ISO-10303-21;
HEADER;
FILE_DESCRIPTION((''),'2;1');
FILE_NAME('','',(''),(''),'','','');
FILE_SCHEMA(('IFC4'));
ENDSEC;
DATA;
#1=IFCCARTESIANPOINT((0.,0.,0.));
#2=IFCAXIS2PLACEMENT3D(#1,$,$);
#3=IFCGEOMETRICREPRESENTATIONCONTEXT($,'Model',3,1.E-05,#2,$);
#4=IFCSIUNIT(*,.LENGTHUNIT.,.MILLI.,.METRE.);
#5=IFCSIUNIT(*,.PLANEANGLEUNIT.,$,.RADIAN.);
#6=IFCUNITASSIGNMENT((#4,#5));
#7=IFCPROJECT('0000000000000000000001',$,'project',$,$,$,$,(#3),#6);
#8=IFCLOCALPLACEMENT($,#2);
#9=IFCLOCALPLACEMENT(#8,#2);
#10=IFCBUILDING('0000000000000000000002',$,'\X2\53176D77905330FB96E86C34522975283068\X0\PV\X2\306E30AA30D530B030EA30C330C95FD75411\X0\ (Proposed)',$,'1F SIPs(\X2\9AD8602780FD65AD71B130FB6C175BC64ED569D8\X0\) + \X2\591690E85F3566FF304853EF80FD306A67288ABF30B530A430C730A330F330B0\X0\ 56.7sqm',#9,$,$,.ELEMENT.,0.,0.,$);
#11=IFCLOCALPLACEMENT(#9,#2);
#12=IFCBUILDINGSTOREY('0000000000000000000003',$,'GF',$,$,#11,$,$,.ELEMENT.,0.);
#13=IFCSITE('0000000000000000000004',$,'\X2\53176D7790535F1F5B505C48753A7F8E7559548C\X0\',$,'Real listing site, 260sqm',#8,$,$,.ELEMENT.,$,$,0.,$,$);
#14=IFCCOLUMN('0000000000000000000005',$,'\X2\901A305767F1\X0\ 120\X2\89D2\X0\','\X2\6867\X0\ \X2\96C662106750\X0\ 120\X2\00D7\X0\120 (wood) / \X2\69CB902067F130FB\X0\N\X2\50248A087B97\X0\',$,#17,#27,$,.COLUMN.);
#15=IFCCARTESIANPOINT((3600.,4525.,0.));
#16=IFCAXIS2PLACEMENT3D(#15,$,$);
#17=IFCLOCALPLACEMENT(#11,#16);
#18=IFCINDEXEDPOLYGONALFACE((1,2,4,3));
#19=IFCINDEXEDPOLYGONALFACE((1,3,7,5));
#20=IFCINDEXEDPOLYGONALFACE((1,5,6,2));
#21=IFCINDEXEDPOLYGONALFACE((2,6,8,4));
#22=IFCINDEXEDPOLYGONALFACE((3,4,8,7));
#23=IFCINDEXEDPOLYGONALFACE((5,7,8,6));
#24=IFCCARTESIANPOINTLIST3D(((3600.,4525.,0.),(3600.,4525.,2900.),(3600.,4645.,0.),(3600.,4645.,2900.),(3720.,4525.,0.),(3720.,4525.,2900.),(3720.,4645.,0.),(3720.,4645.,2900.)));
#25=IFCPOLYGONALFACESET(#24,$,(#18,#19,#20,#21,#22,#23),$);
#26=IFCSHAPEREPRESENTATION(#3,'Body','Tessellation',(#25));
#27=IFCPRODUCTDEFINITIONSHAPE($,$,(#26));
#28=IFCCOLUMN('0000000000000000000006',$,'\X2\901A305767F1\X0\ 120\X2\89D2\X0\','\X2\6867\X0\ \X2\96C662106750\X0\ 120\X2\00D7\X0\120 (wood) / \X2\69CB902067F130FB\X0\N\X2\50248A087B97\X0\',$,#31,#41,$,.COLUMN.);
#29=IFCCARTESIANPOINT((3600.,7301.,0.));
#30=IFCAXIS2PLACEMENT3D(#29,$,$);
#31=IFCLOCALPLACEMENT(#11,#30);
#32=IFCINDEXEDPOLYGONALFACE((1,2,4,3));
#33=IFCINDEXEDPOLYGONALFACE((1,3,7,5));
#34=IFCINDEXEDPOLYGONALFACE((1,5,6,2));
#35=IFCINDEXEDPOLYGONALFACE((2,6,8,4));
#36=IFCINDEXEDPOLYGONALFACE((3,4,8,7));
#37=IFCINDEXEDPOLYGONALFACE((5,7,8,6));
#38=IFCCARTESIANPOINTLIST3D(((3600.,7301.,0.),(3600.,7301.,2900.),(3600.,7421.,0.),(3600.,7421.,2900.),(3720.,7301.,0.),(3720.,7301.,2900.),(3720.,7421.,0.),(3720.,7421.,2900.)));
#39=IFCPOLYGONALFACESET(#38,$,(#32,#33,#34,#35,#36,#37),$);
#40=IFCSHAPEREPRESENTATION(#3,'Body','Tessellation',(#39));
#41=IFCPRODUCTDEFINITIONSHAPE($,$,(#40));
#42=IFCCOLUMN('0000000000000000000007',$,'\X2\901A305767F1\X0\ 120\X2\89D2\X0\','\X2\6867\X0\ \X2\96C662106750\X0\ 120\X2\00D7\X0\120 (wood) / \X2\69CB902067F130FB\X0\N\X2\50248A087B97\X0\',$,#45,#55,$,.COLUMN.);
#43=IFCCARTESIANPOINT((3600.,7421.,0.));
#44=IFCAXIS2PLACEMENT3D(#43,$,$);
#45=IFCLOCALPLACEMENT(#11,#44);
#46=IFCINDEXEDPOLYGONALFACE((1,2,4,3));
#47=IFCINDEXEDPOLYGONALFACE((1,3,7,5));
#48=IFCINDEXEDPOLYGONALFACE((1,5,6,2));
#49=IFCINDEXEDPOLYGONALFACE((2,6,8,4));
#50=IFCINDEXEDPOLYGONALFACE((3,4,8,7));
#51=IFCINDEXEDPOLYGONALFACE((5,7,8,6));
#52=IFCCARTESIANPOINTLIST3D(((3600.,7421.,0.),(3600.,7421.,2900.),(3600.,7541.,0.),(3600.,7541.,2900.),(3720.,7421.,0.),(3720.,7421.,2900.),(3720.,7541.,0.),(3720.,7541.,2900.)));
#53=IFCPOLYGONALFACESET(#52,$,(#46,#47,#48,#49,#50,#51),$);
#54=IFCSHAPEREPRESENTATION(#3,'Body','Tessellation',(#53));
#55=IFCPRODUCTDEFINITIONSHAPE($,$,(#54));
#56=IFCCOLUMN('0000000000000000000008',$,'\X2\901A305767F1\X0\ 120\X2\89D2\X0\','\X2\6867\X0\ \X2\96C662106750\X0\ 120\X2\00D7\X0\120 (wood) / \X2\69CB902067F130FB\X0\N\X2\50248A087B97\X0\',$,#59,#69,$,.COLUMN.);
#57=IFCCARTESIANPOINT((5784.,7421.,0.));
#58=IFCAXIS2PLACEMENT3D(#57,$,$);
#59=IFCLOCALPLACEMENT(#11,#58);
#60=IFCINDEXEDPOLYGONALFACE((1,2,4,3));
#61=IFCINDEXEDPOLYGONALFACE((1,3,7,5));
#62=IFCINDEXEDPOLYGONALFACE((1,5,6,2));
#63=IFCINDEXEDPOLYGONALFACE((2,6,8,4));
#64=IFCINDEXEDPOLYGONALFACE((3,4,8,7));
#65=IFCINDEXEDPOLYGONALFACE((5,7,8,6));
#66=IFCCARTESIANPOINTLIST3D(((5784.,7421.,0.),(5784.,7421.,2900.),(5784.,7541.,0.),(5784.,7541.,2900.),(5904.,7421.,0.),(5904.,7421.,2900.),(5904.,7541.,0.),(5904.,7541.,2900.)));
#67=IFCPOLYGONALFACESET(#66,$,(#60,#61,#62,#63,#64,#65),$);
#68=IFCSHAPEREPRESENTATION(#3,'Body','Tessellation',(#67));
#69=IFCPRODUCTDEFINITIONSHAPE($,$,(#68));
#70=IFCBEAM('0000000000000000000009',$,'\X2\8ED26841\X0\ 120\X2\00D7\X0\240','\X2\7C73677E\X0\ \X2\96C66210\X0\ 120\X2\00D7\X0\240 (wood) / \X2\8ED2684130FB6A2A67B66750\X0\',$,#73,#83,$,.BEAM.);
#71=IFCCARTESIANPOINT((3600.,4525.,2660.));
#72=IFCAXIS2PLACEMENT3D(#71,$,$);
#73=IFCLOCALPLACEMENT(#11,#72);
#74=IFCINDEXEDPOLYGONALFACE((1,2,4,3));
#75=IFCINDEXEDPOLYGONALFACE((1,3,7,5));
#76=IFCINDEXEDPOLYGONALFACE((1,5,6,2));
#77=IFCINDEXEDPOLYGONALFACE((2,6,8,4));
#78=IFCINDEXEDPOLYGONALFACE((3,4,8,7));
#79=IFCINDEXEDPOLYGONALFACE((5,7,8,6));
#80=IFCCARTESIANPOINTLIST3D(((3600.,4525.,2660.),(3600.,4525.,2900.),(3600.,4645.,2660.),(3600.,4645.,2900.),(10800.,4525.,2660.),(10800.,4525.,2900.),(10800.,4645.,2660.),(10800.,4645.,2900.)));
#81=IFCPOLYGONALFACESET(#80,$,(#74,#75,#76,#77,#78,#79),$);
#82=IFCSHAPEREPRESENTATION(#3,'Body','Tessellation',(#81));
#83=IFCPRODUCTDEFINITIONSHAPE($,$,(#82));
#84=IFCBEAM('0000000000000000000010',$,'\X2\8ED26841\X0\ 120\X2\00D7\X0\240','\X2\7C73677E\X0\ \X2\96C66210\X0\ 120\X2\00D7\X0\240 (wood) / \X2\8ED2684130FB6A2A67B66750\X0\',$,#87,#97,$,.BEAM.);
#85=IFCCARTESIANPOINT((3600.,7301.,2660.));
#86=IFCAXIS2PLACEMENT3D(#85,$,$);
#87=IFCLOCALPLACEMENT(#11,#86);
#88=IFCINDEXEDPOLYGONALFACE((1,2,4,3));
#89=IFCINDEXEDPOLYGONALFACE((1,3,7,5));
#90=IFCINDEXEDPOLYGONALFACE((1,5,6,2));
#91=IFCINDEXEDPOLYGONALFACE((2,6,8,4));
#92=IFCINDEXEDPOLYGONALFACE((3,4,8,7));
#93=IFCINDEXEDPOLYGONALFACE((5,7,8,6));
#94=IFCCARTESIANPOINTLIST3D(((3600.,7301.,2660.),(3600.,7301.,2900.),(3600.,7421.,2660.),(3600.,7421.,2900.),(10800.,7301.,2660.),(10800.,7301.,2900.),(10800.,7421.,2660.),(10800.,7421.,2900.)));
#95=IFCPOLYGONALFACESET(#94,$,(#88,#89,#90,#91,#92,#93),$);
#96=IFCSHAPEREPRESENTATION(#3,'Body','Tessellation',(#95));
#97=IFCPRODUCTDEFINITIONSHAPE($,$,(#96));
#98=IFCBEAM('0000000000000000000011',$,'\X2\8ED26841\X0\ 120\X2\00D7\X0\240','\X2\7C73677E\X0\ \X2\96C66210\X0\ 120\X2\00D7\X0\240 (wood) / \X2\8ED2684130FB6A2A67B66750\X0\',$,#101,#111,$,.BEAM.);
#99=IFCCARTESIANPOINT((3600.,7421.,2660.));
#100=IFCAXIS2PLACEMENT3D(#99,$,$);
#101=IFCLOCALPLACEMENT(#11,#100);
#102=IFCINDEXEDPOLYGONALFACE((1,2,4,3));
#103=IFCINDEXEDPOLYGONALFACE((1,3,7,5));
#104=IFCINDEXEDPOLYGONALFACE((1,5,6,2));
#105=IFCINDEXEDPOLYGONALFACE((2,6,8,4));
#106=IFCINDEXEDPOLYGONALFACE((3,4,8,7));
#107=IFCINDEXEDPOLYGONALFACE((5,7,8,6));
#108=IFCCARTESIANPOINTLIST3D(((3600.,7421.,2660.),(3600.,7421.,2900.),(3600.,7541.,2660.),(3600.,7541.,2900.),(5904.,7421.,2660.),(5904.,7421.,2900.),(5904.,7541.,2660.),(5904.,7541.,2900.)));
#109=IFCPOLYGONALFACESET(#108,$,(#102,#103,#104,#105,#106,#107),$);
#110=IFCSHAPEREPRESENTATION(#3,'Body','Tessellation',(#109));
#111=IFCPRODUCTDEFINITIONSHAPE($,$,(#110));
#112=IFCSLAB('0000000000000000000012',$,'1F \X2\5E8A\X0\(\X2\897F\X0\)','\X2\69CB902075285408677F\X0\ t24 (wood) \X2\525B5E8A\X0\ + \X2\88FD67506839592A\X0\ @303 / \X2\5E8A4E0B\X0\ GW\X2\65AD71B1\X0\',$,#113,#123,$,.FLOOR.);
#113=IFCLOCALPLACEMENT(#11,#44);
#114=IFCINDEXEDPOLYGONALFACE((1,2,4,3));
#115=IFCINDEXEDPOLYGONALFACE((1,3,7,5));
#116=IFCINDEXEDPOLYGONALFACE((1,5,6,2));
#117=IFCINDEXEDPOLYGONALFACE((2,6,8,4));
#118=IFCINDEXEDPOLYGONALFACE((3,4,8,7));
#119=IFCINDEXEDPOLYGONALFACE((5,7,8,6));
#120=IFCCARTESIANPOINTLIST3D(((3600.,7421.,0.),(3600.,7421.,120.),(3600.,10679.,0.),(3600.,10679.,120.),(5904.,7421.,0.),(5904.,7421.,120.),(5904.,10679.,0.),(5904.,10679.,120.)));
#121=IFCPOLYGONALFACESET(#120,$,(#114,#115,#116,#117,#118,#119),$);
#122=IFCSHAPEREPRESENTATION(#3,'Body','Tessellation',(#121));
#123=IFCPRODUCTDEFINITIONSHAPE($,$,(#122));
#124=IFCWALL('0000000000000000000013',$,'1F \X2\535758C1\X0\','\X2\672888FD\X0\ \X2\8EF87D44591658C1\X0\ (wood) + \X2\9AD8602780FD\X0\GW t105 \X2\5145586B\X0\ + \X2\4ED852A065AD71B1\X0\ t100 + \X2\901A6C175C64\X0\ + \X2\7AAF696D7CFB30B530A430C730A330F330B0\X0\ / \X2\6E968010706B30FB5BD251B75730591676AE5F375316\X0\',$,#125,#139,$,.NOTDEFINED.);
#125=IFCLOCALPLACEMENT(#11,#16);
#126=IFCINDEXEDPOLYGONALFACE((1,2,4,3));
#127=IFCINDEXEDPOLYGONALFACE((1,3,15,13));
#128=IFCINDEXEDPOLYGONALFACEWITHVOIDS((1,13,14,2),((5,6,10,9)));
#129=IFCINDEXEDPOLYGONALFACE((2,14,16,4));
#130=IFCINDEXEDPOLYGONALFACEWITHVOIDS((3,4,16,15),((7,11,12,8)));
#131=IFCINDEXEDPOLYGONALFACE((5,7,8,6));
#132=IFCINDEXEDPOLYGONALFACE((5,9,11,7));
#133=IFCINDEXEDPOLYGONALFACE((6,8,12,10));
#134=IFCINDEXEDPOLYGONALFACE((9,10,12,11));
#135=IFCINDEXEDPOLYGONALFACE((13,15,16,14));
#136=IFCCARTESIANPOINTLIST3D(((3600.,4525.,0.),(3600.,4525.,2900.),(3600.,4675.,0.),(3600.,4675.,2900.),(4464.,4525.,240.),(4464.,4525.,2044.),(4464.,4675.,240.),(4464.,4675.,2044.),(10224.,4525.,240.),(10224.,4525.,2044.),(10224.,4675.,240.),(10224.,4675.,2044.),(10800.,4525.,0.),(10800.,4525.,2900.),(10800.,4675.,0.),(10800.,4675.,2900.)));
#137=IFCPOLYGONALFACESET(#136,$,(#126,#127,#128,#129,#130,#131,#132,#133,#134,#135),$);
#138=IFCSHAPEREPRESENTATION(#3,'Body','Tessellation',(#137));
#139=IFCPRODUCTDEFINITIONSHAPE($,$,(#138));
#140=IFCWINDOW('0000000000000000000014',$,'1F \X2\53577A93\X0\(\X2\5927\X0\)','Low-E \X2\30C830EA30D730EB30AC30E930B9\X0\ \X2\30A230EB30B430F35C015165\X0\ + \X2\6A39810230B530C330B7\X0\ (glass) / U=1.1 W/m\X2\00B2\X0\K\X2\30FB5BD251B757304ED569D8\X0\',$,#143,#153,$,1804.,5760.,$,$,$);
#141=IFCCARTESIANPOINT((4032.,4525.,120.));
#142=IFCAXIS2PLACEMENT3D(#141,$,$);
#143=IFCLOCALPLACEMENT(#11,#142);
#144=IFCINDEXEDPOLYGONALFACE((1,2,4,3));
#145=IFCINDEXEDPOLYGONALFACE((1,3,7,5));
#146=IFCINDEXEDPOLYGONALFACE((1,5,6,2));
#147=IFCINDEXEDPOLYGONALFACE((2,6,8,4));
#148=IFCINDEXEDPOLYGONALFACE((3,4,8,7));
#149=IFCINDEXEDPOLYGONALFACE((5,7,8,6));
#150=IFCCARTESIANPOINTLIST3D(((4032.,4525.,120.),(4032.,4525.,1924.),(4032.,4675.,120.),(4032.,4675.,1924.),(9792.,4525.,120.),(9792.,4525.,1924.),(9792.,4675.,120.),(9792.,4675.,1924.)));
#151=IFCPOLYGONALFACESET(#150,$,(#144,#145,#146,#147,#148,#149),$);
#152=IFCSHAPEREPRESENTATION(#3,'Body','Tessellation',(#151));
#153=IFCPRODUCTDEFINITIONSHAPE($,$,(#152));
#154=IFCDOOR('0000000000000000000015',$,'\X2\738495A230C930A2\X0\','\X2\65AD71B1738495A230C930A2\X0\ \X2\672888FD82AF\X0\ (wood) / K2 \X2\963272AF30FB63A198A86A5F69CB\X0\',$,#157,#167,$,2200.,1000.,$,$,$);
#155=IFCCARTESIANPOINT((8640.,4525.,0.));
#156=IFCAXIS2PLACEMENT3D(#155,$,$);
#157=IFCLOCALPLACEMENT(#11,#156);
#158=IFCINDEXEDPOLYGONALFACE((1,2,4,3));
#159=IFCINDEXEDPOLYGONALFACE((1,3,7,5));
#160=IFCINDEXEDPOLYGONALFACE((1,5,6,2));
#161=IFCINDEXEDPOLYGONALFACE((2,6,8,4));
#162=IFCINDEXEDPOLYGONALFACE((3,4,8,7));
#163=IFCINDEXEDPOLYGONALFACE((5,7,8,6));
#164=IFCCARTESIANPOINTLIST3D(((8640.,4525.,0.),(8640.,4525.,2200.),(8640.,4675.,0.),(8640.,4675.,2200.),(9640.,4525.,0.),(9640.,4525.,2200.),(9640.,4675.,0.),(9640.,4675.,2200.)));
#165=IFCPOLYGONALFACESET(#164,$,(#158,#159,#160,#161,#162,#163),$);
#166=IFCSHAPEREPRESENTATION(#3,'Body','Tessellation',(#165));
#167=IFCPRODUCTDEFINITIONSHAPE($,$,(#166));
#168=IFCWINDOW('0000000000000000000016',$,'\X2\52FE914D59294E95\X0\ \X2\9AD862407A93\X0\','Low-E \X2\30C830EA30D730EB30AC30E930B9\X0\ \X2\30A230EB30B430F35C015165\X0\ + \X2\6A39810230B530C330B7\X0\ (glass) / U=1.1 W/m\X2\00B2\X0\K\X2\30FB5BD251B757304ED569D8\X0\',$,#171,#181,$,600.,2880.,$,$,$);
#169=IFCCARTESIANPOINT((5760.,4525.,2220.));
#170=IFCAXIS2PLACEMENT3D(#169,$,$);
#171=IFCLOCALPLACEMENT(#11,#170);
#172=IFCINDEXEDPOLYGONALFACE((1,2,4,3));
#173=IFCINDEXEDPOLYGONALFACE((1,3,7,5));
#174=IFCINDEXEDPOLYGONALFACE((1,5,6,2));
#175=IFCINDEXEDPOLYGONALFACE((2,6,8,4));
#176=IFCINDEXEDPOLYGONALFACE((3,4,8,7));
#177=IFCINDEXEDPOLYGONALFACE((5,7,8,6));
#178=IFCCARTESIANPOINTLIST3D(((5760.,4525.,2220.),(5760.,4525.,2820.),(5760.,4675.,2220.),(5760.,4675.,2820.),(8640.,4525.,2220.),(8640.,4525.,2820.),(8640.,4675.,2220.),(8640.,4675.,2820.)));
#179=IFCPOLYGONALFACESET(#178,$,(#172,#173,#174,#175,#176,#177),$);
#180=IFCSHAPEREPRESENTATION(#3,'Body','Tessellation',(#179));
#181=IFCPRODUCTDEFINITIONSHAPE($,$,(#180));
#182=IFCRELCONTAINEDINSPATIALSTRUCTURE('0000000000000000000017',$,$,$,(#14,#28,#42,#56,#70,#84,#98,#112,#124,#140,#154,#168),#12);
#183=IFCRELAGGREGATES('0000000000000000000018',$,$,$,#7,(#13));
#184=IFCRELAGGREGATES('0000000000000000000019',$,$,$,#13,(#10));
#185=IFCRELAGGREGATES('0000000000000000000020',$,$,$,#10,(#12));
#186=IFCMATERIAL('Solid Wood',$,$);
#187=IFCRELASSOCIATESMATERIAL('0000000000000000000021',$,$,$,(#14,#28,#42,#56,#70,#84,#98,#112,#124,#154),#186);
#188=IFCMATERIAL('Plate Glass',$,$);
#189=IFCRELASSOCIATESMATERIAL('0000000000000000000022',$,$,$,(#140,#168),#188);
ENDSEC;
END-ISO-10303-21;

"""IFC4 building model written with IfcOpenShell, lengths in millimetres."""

from ifc_helpers import new_model, si_unit, frame, frame_2d, origin, place, context, project, spatial, rectangle, extrude, material, element, fill, save


model = new_model("IFC4")

# Units and contexts
model_context = context("Model", 3, precision=1e-05, world=origin())
ifc_project = project(units=[si_unit("LENGTHUNIT", "METRE", prefix="MILLI"), si_unit("PLANEANGLEUNIT", "RADIAN")], contexts=[model_context])

# Site, building, storey
site_placement = place(None, origin())
site = spatial("IfcSite", under=ifc_project, at=site_placement, Name="北海道弟子屈町美留和", ObjectType="Real listing site, 260sqm", CompositionType="ELEMENT", RefElevation=0.0)
building_placement = place(site_placement, origin())
building = spatial("IfcBuilding", under=site, at=building_placement, Name="北海道・雨水利用とPVのオフグリッド志向 (Proposed)", ObjectType="1F SIPs(高性能断熱・気密仕様) + 外部張替え可能な木調サイディング 56.7sqm", CompositionType="ELEMENT", ElevationOfRefHeight=0.0, ElevationOfTerrain=0.0)
storey_placement = place(building_placement, origin())
storey = spatial("IfcBuildingStorey", under=building, at=storey_placement, Name="GF", CompositionType="ELEMENT", Elevation=0.0)

# Columns
ifc_material_1 = material(Name="Solid Wood")
column_1_placement = place(storey_placement, frame((3600.0, 4525.0, 0.0)))
element("IfcColumn", 1, at=column_1_placement, inside=storey, material=ifc_material_1, Name="通し柱 120角", Description="桧 集成材 120×120 (wood) / 構造柱・N値計算", PredefinedType="COLUMN", context=model_context, shape_type="SweptSolid", body=[
    extrude(rectangle(XDim=120.0, YDim=120.0, at=frame_2d((60.0, 60.0))), frame((3600.0, 4525.0, 0.0)), (0.0, 0.0, 1.0), 2900.0),
])
column_2_placement = place(storey_placement, frame((3600.0, 7301.0, 0.0)))
element("IfcColumn", 2, at=column_2_placement, inside=storey, material=ifc_material_1, Name="通し柱 120角", Description="桧 集成材 120×120 (wood) / 構造柱・N値計算", PredefinedType="COLUMN", context=model_context, shape_type="SweptSolid", body=[
    extrude(rectangle(XDim=120.0, YDim=120.0, at=frame_2d((60.0, 60.0))), frame((3600.0, 7301.0, 0.0)), (0.0, 0.0, 1.0), 2900.0),
])
column_3_placement = place(storey_placement, frame((3600.0, 7421.0, 0.0)))
element("IfcColumn", 3, at=column_3_placement, inside=storey, material=ifc_material_1, Name="通し柱 120角", Description="桧 集成材 120×120 (wood) / 構造柱・N値計算", PredefinedType="COLUMN", context=model_context, shape_type="SweptSolid", body=[
    extrude(rectangle(XDim=120.0, YDim=120.0, at=frame_2d((60.0, 60.0))), frame((3600.0, 7421.0, 0.0)), (0.0, 0.0, 1.0), 2900.0),
])
column_4_placement = place(storey_placement, frame((5784.0, 7421.0, 0.0)))
element("IfcColumn", 4, at=column_4_placement, inside=storey, material=ifc_material_1, Name="通し柱 120角", Description="桧 集成材 120×120 (wood) / 構造柱・N値計算", PredefinedType="COLUMN", context=model_context, shape_type="SweptSolid", body=[
    extrude(rectangle(XDim=120.0, YDim=120.0, at=frame_2d((60.0, 60.0))), frame((5784.0, 7421.0, 0.0)), (0.0, 0.0, 1.0), 2900.0),
])

# Beams
beam_1_placement = place(storey_placement, frame((3600.0, 4525.0, 2660.0)))
element("IfcBeam", 5, at=beam_1_placement, inside=storey, material=ifc_material_1, Name="軒桁 120×240", Description="米松 集成 120×240 (wood) / 軒桁・横架材", PredefinedType="BEAM", context=model_context, shape_type="SweptSolid", body=[
    extrude(rectangle(XDim=7200.0, YDim=120.0, at=frame_2d((3600.0, 60.0))), frame((3600.0, 4525.0, 2660.0)), (0.0, 0.0, 1.0), 240.0),
])
beam_2_placement = place(storey_placement, frame((3600.0, 7301.0, 2660.0)))
element("IfcBeam", 6, at=beam_2_placement, inside=storey, material=ifc_material_1, Name="軒桁 120×240", Description="米松 集成 120×240 (wood) / 軒桁・横架材", PredefinedType="BEAM", context=model_context, shape_type="SweptSolid", body=[
    extrude(rectangle(XDim=7200.0, YDim=120.0, at=frame_2d((3600.0, 60.0))), frame((3600.0, 7301.0, 2660.0)), (0.0, 0.0, 1.0), 240.0),
])
beam_3_placement = place(storey_placement, frame((3600.0, 7421.0, 2660.0)))
element("IfcBeam", 7, at=beam_3_placement, inside=storey, material=ifc_material_1, Name="軒桁 120×240", Description="米松 集成 120×240 (wood) / 軒桁・横架材", PredefinedType="BEAM", context=model_context, shape_type="SweptSolid", body=[
    extrude(rectangle(XDim=2304.0, YDim=120.0, at=frame_2d((1152.0, 60.0))), frame((3600.0, 7421.0, 2660.0)), (0.0, 0.0, 1.0), 240.0),
])

# Slab
slab_1_placement = place(storey_placement, frame((3600.0, 7421.0, 0.0)))
element("IfcSlab", 8, at=slab_1_placement, inside=storey, material=ifc_material_1, Name="1F 床(西)", Description="構造用合板 t24 (wood) 剛床 + 製材根太 @303 / 床下 GW断熱", PredefinedType="FLOOR", context=model_context, shape_type="SweptSolid", body=[
    extrude(rectangle(XDim=2304.0, YDim=3258.0, at=frame_2d((1152.0, 1629.0))), frame((3600.0, 7421.0, 0.0)), (0.0, 0.0, 1.0), 120.0),
])

# Wall, openings, windows, door
wall_1_placement = place(storey_placement, frame((3600.0, 4525.0, 0.0)))
wall_1 = element("IfcWall", 9, at=wall_1_placement, inside=storey, material=ifc_material_1, Name="1F 南壁", Description="木製 軸組外壁 (wood) + 高性能GW t105 充填 + 付加断熱 t100 + 通気層 + 窯業系サイディング / 準耐火・寒冷地外皮強化", PredefinedType="NOTDEFINED", context=model_context, shape_type="SweptSolid", body=[
    extrude(rectangle(XDim=7200.0, YDim=150.0, at=frame_2d((3600.0, 75.0))), frame((3600.0, 4525.0, 0.0)), (0.0, 0.0, 1.0), 2900.0),
])
opening_1_placement = place(storey_placement, frame((4032.0, 4525.0, 120.0)))
opening_1 = element("IfcOpeningElement", 10, at=opening_1_placement, cuts=wall_1, PredefinedType="NOTDEFINED", context=model_context, shape_type="SweptSolid", body=[
    extrude(rectangle(XDim=5760.0, YDim=150.0, at=frame_2d((2880.0, 75.0))), frame((4032.0, 4525.0, 120.0)), (0.0, 0.0, 1.0), 1804.0),
])
opening_2_placement = place(storey_placement, frame((8640.0, 4525.0, 0.0)))
opening_2 = element("IfcOpeningElement", 11, at=opening_2_placement, cuts=wall_1, PredefinedType="NOTDEFINED", context=model_context, shape_type="SweptSolid", body=[
    extrude(rectangle(XDim=1000.0, YDim=150.0, at=frame_2d((500.0, 75.0))), frame((8640.0, 4525.0, 0.0)), (0.0, 0.0, 1.0), 2200.0),
])
opening_3_placement = place(storey_placement, frame((5760.0, 4525.0, 2220.0)))
opening_3 = element("IfcOpeningElement", 12, at=opening_3_placement, cuts=wall_1, PredefinedType="NOTDEFINED", context=model_context, shape_type="SweptSolid", body=[
    extrude(rectangle(XDim=2880.0, YDim=150.0, at=frame_2d((1440.0, 75.0))), frame((5760.0, 4525.0, 2220.0)), (0.0, 0.0, 1.0), 600.0),
])
ifc_material_2 = material(Name="Plate Glass")
window_1_placement = place(storey_placement, frame((4032.0, 4525.0, 120.0)))
window_1 = element("IfcWindow", 13, at=window_1_placement, inside=storey, material=ifc_material_2, Name="1F 南窓(大)", Description="Low-E トリプルガラス アルゴン封入 + 樹脂サッシ (glass) / U=1.1 W/m²K・寒冷地仕様", OverallHeight=1804.0, OverallWidth=5760.0, context=model_context, shape_type="SweptSolid", body=[
    extrude(rectangle(XDim=5760.0, YDim=150.0, at=frame_2d((2880.0, 75.0))), frame((4032.0, 4525.0, 120.0)), (0.0, 0.0, 1.0), 1804.0),
])
fill(opening_1, window_1)
door_placement = place(storey_placement, frame((8640.0, 4525.0, 0.0)))
door = element("IfcDoor", 14, at=door_placement, inside=storey, material=ifc_material_1, Name="玄関ドア", Description="断熱玄関ドア 木製芯 (wood) / K2 防犯・採風機構", OverallHeight=2200.0, OverallWidth=1000.0, context=model_context, shape_type="SweptSolid", body=[
    extrude(rectangle(XDim=1000.0, YDim=150.0, at=frame_2d((500.0, 75.0))), frame((8640.0, 4525.0, 0.0)), (0.0, 0.0, 1.0), 2200.0),
])
fill(opening_2, door)
window_2_placement = place(storey_placement, frame((5760.0, 4525.0, 2220.0)))
window_2 = element("IfcWindow", 15, at=window_2_placement, inside=storey, material=ifc_material_2, Name="勾配天井 高所窓", Description="Low-E トリプルガラス アルゴン封入 + 樹脂サッシ (glass) / U=1.1 W/m²K・寒冷地仕様", OverallHeight=600.0, OverallWidth=2880.0, context=model_context, shape_type="SweptSolid", body=[
    extrude(rectangle(XDim=2880.0, YDim=150.0, at=frame_2d((1440.0, 75.0))), frame((5760.0, 4525.0, 2220.0)), (0.0, 0.0, 1.0), 600.0),
])
fill(opening_3, window_2)

save(model, "model.ifc")
